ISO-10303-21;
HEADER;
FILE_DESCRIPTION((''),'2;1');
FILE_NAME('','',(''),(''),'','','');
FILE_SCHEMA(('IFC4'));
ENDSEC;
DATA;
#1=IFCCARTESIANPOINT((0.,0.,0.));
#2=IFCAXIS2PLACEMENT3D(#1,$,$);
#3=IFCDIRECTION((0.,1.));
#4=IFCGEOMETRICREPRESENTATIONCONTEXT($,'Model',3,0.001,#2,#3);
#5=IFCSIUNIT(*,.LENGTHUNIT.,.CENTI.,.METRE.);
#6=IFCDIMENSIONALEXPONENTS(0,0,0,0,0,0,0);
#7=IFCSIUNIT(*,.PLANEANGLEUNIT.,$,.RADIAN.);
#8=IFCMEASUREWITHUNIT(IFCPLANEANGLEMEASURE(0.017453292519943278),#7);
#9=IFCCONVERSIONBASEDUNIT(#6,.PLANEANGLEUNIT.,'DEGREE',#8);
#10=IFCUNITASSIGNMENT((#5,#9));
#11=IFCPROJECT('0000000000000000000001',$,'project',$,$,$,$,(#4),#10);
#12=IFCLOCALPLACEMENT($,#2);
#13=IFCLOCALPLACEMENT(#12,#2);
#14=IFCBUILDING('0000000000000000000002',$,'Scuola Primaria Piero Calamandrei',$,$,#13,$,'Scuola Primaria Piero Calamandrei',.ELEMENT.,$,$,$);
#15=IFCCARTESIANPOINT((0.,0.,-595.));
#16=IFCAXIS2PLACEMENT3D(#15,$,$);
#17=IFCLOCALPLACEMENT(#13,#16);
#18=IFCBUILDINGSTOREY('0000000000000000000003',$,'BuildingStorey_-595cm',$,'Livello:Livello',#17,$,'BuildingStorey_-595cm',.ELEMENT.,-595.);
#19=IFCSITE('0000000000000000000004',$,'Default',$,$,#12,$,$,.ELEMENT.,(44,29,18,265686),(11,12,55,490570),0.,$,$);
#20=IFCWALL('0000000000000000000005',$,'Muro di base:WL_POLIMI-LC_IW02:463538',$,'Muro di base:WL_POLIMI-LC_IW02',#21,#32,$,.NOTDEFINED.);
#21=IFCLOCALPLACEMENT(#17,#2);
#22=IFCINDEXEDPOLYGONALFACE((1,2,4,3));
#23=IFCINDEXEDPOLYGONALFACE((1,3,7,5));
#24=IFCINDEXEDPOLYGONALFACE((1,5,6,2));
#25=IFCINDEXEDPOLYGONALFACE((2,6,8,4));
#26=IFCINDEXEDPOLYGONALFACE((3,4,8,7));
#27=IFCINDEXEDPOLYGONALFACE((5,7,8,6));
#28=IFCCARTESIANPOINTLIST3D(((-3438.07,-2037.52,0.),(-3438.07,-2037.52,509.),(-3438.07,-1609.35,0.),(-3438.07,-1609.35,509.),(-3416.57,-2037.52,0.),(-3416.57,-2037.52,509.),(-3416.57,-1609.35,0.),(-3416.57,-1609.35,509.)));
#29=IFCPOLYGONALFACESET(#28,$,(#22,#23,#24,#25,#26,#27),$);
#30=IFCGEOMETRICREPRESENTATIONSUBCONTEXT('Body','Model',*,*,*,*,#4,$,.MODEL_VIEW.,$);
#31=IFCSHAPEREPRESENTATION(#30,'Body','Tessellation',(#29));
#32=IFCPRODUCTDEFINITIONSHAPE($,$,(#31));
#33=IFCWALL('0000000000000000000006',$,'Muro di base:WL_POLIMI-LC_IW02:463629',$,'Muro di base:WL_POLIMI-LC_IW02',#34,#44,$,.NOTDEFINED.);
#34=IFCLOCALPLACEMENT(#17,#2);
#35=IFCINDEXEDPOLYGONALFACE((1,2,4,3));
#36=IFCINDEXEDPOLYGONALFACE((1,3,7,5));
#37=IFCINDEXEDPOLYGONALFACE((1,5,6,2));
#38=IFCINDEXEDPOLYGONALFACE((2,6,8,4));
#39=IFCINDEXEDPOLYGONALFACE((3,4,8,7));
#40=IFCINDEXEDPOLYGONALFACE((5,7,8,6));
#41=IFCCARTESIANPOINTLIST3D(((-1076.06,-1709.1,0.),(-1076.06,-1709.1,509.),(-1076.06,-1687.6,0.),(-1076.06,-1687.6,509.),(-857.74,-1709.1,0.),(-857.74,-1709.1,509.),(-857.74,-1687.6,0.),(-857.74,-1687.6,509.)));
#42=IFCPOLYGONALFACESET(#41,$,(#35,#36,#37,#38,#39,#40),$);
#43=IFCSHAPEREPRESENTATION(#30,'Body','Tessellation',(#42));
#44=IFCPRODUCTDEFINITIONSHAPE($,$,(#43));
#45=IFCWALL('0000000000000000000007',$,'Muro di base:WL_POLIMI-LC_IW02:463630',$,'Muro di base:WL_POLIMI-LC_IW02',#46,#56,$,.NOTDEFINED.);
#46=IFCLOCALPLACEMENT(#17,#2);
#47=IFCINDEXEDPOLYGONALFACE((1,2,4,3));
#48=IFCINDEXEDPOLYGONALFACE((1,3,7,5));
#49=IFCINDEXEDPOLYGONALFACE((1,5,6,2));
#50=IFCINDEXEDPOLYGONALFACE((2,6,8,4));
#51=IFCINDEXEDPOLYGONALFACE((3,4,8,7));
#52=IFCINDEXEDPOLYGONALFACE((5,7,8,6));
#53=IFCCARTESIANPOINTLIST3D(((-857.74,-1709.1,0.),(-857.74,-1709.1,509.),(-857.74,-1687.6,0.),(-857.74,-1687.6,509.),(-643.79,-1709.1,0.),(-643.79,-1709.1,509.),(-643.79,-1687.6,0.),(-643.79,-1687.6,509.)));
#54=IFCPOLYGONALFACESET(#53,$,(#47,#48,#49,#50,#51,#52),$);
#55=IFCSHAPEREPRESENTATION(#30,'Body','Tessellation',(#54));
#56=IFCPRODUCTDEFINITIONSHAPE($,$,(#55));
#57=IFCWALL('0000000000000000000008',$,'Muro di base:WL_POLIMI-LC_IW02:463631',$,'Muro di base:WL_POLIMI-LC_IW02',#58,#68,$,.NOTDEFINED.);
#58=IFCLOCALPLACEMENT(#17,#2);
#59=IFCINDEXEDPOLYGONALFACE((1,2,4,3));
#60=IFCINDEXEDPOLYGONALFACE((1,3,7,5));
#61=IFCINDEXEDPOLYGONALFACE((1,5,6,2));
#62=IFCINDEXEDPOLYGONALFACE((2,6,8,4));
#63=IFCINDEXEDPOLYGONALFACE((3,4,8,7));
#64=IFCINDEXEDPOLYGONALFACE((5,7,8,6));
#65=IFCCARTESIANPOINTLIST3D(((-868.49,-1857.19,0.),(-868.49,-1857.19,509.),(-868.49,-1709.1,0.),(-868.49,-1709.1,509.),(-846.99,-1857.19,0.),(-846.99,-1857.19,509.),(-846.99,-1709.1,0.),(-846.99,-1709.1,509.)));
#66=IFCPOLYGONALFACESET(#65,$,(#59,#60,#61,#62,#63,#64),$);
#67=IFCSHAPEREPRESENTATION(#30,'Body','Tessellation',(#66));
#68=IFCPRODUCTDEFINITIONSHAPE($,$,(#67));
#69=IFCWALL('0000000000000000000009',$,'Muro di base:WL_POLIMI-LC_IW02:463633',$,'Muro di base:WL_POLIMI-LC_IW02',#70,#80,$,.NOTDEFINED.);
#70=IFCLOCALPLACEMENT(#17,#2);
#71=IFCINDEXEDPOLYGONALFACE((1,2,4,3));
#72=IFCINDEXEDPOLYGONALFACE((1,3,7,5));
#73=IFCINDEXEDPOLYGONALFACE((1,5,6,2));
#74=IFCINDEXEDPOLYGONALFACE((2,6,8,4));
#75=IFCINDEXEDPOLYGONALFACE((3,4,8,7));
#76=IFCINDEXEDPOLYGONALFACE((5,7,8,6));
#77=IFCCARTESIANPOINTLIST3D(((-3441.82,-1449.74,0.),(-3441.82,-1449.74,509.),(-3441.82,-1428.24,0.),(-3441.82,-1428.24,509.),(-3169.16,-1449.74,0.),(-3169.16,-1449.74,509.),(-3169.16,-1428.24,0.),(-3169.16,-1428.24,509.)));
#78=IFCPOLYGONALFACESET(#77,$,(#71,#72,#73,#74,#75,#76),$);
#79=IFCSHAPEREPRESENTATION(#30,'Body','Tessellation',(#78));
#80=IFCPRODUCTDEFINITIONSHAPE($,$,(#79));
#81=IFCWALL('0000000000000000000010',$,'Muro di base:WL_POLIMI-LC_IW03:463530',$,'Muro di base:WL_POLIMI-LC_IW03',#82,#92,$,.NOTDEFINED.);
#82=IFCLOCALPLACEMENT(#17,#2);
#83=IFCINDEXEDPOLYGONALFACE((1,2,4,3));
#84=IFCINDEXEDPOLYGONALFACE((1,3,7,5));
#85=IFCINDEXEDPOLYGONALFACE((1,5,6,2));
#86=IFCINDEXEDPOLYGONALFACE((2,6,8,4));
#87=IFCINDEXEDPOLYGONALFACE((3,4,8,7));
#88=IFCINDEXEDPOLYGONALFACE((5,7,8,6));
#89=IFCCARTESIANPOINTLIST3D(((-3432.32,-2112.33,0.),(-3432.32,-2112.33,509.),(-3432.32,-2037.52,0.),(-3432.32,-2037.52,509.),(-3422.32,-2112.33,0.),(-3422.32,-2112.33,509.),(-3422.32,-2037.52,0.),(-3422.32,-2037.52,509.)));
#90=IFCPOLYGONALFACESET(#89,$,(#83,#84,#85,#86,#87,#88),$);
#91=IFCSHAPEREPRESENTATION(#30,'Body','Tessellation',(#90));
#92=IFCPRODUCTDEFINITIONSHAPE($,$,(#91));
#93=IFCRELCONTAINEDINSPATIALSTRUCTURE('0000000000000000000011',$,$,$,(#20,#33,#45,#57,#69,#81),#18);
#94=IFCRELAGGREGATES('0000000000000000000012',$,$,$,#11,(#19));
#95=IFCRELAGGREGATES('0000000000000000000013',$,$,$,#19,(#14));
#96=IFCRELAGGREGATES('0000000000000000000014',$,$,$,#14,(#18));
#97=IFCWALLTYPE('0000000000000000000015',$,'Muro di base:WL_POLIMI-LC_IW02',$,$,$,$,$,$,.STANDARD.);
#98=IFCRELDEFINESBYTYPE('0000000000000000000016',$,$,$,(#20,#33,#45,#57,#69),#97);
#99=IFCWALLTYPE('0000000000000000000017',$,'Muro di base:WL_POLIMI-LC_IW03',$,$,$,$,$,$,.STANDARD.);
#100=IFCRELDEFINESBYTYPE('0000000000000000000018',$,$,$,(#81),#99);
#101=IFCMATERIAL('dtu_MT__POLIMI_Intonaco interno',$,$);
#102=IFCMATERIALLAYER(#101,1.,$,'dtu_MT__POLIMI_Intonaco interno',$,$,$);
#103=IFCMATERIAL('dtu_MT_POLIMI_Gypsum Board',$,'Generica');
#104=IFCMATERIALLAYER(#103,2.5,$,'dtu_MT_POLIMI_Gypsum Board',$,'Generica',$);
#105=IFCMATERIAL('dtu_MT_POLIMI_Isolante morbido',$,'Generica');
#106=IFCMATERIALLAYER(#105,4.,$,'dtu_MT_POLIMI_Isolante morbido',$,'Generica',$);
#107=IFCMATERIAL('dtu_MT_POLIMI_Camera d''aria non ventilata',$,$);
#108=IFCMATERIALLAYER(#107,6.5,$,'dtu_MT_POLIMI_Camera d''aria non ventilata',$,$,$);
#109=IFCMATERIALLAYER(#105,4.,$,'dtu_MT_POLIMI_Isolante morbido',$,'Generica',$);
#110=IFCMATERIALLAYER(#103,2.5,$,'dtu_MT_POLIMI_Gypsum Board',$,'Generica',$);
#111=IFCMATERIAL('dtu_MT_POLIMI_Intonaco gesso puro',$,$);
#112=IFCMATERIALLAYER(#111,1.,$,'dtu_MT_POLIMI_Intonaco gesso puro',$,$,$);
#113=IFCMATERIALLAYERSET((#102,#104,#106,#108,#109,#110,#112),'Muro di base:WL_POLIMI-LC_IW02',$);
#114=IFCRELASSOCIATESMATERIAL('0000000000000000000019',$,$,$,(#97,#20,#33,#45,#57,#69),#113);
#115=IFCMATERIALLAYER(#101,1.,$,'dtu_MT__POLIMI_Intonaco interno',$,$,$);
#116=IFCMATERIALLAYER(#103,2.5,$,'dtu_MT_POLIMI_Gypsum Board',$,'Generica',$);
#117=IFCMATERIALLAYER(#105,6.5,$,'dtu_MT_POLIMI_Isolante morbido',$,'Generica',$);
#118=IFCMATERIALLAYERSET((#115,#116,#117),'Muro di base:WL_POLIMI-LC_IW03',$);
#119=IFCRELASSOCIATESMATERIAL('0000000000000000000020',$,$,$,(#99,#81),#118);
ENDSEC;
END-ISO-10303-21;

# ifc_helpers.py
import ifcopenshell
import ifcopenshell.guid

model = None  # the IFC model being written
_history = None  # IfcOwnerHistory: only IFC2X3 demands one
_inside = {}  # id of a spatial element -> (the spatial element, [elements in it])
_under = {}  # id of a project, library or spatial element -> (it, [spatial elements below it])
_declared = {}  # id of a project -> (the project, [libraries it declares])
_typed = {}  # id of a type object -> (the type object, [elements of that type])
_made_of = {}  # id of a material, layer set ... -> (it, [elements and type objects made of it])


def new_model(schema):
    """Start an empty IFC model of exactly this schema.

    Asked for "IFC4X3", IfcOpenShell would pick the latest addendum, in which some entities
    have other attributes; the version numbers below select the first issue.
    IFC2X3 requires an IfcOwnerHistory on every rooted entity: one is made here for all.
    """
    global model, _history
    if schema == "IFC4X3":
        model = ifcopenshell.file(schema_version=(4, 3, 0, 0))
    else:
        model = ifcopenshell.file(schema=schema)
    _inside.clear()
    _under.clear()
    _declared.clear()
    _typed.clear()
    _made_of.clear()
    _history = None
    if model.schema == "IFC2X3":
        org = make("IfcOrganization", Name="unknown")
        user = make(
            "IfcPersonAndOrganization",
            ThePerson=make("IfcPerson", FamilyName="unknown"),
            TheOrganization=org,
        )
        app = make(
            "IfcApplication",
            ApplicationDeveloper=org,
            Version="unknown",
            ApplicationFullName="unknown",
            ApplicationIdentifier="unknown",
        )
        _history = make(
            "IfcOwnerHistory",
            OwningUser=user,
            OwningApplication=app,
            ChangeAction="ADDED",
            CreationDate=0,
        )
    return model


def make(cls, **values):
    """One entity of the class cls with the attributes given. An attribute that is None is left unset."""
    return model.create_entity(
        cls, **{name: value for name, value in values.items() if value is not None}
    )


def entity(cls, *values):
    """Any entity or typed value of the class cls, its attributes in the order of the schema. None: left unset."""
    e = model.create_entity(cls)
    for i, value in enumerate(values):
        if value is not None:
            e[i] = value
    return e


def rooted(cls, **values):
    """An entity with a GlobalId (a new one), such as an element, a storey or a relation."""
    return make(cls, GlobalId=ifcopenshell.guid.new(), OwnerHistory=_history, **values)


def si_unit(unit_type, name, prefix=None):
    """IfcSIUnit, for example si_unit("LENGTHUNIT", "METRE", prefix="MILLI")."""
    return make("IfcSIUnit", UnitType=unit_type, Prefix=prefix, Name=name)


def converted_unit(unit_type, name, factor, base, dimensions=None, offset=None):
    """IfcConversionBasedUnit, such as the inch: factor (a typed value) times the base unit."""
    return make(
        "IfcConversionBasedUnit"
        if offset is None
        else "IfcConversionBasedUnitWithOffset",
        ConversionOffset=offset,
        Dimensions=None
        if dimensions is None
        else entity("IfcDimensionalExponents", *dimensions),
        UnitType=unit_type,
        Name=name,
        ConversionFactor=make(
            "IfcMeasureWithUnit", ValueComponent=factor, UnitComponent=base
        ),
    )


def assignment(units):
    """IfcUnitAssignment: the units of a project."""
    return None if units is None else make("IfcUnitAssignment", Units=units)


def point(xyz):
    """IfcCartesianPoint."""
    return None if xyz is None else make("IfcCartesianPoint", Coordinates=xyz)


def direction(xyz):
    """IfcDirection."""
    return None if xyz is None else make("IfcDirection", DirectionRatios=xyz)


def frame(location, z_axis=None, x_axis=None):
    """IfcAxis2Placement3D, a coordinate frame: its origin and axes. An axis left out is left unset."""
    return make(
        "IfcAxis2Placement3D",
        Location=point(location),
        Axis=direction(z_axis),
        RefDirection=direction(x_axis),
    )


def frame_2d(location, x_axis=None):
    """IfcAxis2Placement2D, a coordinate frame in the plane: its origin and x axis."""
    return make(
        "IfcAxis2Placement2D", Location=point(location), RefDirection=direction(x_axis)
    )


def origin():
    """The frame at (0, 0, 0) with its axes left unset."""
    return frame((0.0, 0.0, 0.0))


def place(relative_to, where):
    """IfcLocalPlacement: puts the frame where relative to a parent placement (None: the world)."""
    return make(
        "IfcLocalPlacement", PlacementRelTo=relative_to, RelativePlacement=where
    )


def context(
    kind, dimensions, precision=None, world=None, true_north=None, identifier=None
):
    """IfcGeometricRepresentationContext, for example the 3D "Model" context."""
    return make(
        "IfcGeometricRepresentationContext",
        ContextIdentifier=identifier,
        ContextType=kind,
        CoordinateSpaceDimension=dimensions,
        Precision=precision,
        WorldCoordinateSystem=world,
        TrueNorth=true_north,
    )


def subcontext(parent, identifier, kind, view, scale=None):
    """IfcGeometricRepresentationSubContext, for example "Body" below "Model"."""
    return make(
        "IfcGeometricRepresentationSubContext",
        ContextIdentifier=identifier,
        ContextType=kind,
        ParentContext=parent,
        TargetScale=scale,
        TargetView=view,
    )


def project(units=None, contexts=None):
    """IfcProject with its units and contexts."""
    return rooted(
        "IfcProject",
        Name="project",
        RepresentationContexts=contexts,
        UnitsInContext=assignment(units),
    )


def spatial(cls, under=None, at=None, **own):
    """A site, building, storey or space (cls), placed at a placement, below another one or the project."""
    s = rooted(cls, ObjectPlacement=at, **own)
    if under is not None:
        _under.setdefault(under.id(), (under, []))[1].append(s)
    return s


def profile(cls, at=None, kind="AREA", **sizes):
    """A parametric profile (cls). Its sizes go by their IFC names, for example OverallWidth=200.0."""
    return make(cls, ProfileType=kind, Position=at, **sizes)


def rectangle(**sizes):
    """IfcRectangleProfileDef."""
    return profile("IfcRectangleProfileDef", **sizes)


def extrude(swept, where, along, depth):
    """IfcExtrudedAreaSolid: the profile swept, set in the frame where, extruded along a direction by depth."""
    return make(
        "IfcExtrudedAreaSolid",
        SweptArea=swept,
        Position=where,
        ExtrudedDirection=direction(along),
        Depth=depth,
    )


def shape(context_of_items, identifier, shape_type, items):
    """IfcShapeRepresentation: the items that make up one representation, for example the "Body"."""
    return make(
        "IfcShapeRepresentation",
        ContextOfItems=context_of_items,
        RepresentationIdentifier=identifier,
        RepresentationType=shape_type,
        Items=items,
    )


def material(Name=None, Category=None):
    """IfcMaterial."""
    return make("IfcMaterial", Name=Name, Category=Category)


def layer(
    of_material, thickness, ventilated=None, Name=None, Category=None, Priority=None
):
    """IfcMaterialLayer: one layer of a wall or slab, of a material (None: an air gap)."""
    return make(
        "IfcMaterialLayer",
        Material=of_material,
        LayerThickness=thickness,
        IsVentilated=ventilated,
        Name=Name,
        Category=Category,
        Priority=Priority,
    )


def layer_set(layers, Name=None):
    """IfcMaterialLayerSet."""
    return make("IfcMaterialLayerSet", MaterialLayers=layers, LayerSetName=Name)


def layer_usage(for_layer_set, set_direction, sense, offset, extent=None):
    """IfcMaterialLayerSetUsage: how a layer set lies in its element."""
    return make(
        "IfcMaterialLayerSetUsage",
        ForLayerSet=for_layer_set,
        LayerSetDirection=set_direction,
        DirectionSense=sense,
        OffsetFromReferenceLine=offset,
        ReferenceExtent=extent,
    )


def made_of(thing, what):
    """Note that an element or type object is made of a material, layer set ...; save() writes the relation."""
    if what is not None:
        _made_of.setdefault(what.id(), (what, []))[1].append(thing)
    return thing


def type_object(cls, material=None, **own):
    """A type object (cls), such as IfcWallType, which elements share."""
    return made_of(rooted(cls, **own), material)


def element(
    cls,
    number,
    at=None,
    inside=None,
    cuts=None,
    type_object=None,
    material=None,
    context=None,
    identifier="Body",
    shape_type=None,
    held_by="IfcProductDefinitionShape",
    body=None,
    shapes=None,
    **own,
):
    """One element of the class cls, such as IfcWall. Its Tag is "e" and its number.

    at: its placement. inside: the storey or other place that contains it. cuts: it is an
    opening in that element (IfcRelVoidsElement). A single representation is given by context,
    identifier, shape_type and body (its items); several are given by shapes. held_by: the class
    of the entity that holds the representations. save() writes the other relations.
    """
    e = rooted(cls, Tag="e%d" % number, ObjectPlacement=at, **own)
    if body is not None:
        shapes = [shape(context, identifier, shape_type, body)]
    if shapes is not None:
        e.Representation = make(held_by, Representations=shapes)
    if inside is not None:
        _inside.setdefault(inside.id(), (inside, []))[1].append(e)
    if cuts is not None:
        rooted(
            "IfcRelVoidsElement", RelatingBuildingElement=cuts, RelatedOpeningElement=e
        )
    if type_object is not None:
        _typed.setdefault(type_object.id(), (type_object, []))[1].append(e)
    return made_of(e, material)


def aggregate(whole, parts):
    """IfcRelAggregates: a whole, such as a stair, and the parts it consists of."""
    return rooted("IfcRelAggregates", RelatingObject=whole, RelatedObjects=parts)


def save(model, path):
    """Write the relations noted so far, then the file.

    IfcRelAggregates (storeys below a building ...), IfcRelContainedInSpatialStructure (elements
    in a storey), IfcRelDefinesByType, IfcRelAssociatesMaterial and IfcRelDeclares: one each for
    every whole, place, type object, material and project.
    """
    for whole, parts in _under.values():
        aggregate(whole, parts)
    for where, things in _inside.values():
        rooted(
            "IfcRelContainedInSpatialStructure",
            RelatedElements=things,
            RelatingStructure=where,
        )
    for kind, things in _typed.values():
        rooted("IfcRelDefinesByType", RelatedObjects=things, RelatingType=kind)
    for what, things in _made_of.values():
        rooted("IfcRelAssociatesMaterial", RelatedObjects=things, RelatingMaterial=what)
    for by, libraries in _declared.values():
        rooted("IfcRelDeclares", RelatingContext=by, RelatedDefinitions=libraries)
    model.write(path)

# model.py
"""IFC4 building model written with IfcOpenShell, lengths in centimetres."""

from ifc_helpers import new_model, entity, si_unit, converted_unit, direction, frame, frame_2d, origin, place, context, subcontext, project, spatial, rectangle, extrude, material, layer, layer_set, layer_usage, type_object, element, save


model = new_model("IFC4")

# Units and contexts
model_context = context("Model", 3, precision=0.001, world=origin(), true_north=direction((0.0, 1.0)))
body_context = subcontext(model_context, "Body", "Model", "MODEL_VIEW")
ifc_project = project(units=[si_unit("LENGTHUNIT", "METRE", prefix="CENTI"), converted_unit("PLANEANGLEUNIT", "DEGREE", entity("IfcPlaneAngleMeasure", 0.017453292519943278), si_unit("PLANEANGLEUNIT", "RADIAN"), dimensions=[0, 0, 0, 0, 0, 0, 0])], contexts=[model_context])

# Site, building, storey
site_placement = place(None, origin())
site = spatial("IfcSite", under=ifc_project, at=site_placement, Name="Default", CompositionType="ELEMENT", RefLatitude=(44, 29, 18, 265686), RefLongitude=(11, 12, 55, 490570), RefElevation=0.0)
building_placement = place(site_placement, origin())
building = spatial("IfcBuilding", under=site, at=building_placement, Name="Scuola Primaria Piero Calamandrei", LongName="Scuola Primaria Piero Calamandrei", CompositionType="ELEMENT")
storey_placement = place(building_placement, frame((0.0, 0.0, -595.0)))
storey = spatial("IfcBuildingStorey", under=building, at=storey_placement, Name="BuildingStorey_-595cm", ObjectType="Livello:Livello", LongName="BuildingStorey_-595cm", CompositionType="ELEMENT", Elevation=-595.0)

# Shared definitions
ifc_material_1 = material(Name="dtu_MT__POLIMI_Intonaco interno")

# Shared definitions
ifc_layer_1 = layer(ifc_material_1, 1.0, Name="dtu_MT__POLIMI_Intonaco interno")
ifc_material_2 = material(Name="dtu_MT_POLIMI_Gypsum Board", Category="Generica")
ifc_layer_2 = layer(ifc_material_2, 2.5, Name="dtu_MT_POLIMI_Gypsum Board", Category="Generica")
ifc_material_3 = material(Name="dtu_MT_POLIMI_Isolante morbido", Category="Generica")
ifc_layer_3 = layer(ifc_material_3, 4.0, Name="dtu_MT_POLIMI_Isolante morbido", Category="Generica")
ifc_material_4 = material(Name="dtu_MT_POLIMI_Camera d'aria non ventilata")
ifc_layer_4 = layer(ifc_material_4, 6.5, Name="dtu_MT_POLIMI_Camera d'aria non ventilata")
ifc_layer_5 = layer(ifc_material_3, 4.0, Name="dtu_MT_POLIMI_Isolante morbido", Category="Generica")
ifc_layer_6 = layer(ifc_material_2, 2.5, Name="dtu_MT_POLIMI_Gypsum Board", Category="Generica")
ifc_material_5 = material(Name="dtu_MT_POLIMI_Intonaco gesso puro")
ifc_layer_7 = layer(ifc_material_5, 1.0, Name="dtu_MT_POLIMI_Intonaco gesso puro")
ifc_layer_set_1 = layer_set([ifc_layer_1, ifc_layer_2, ifc_layer_3, ifc_layer_4, ifc_layer_5, ifc_layer_6, ifc_layer_7], Name="Muro di base:WL_POLIMI-LC_IW02")
wall_type_1 = type_object("IfcWallType", Name="Muro di base:WL_POLIMI-LC_IW02", PredefinedType="STANDARD", material=ifc_layer_set_1)

# Walls
ifc_layer_usage_1 = layer_usage(ifc_layer_set_1, "AXIS2", "NEGATIVE", 10.75)
wall_1_placement = place(storey_placement, frame((-3427.32, -2037.52, 0.0), z_axis=(0.0, 0.0, 1.0), x_axis=(0.0, 1.0, 0.0)))
element("IfcWall", 1, at=wall_1_placement, inside=storey, type_object=wall_type_1, material=ifc_layer_usage_1, Name="Muro di base:WL_POLIMI-LC_IW02:463538", ObjectType="Muro di base:WL_POLIMI-LC_IW02", PredefinedType="NOTDEFINED", context=body_context, shape_type="SweptSolid", body=[
    extrude(rectangle(XDim=428.17, YDim=21.5, at=frame_2d((214.09, 0.0), x_axis=(-1.0, 0.0))), origin(), (0.0, 0.0, 1.0), 509.0),
])
ifc_layer_usage_2 = layer_usage(ifc_layer_set_1, "AXIS2", "NEGATIVE", 10.75)
wall_2_placement = place(storey_placement, frame((-857.74, -1698.35, 0.0), z_axis=(0.0, 0.0, 1.0), x_axis=(-1.0, 0.0, 0.0)))
element("IfcWall", 2, at=wall_2_placement, inside=storey, type_object=wall_type_1, material=ifc_layer_usage_2, Name="Muro di base:WL_POLIMI-LC_IW02:463629", ObjectType="Muro di base:WL_POLIMI-LC_IW02", PredefinedType="NOTDEFINED", context=body_context, shape_type="SweptSolid", body=[
    extrude(rectangle(XDim=218.32, YDim=21.5, at=frame_2d((109.16, 0.0), x_axis=(-1.0, 0.0))), origin(), (0.0, 0.0, 1.0), 509.0),
])
ifc_layer_usage_3 = layer_usage(ifc_layer_set_1, "AXIS2", "NEGATIVE", 10.75)
wall_3_placement = place(storey_placement, frame((-643.79, -1698.35, 0.0), z_axis=(0.0, 0.0, 1.0), x_axis=(-1.0, 0.0, 0.0)))
element("IfcWall", 3, at=wall_3_placement, inside=storey, type_object=wall_type_1, material=ifc_layer_usage_3, Name="Muro di base:WL_POLIMI-LC_IW02:463630", ObjectType="Muro di base:WL_POLIMI-LC_IW02", PredefinedType="NOTDEFINED", context=body_context, shape_type="SweptSolid", body=[
    extrude(rectangle(XDim=213.95, YDim=21.5, at=frame_2d((106.98, 0.0), x_axis=(-1.0, 0.0))), origin(), (0.0, 0.0, 1.0), 509.0),
])
ifc_layer_usage_4 = layer_usage(ifc_layer_set_1, "AXIS2", "NEGATIVE", 10.75)
wall_4_placement = place(storey_placement, frame((-857.74, -1709.1, 0.0), z_axis=(0.0, 0.0, 1.0), x_axis=(0.0, -1.0, 0.0)))
element("IfcWall", 4, at=wall_4_placement, inside=storey, type_object=wall_type_1, material=ifc_layer_usage_4, Name="Muro di base:WL_POLIMI-LC_IW02:463631", ObjectType="Muro di base:WL_POLIMI-LC_IW02", PredefinedType="NOTDEFINED", context=body_context, shape_type="SweptSolid", body=[
    extrude(rectangle(XDim=148.08, YDim=21.5, at=frame_2d((74.04, 0.0), x_axis=(-1.0, 0.0))), origin(), (0.0, 0.0, 1.0), 509.0),
])
ifc_layer_usage_5 = layer_usage(ifc_layer_set_1, "AXIS2", "NEGATIVE", 10.75)
wall_5_placement = place(storey_placement, frame((-3169.16, -1438.99, 0.0), z_axis=(0.0, 0.0, 1.0), x_axis=(-1.0, 0.0, 0.0)))
element("IfcWall", 5, at=wall_5_placement, inside=storey, type_object=wall_type_1, material=ifc_layer_usage_5, Name="Muro di base:WL_POLIMI-LC_IW02:463633", ObjectType="Muro di base:WL_POLIMI-LC_IW02", PredefinedType="NOTDEFINED", context=body_context, shape_type="SweptSolid", body=[
    extrude(rectangle(XDim=272.66, YDim=21.5, at=frame_2d((136.33, 0.0), x_axis=(-1.0, 0.0))), origin(), (0.0, 0.0, 1.0), 509.0),
])
ifc_layer_8 = layer(ifc_material_1, 1.0, Name="dtu_MT__POLIMI_Intonaco interno")
ifc_layer_9 = layer(ifc_material_2, 2.5, Name="dtu_MT_POLIMI_Gypsum Board", Category="Generica")
ifc_layer_10 = layer(ifc_material_3, 6.5, Name="dtu_MT_POLIMI_Isolante morbido", Category="Generica")
ifc_layer_set_2 = layer_set([ifc_layer_8, ifc_layer_9, ifc_layer_10], Name="Muro di base:WL_POLIMI-LC_IW03")
ifc_layer_usage_6 = layer_usage(ifc_layer_set_2, "AXIS2", "NEGATIVE", 5.0)
wall_type_2 = type_object("IfcWallType", Name="Muro di base:WL_POLIMI-LC_IW03", PredefinedType="STANDARD", material=ifc_layer_set_2)
wall_6_placement = place(storey_placement, frame((-3427.32, -2112.33, 0.0), z_axis=(0.0, 0.0, 1.0), x_axis=(0.0, 1.0, 0.0)))
element("IfcWall", 6, at=wall_6_placement, inside=storey, type_object=wall_type_2, material=ifc_layer_usage_6, Name="Muro di base:WL_POLIMI-LC_IW03:463530", ObjectType="Muro di base:WL_POLIMI-LC_IW03", PredefinedType="NOTDEFINED", context=body_context, shape_type="SweptSolid", body=[
    extrude(rectangle(XDim=74.8, YDim=10.0, at=frame_2d((37.4, 0.0), x_axis=(-1.0, 0.0))), origin(), (0.0, 0.0, 1.0), 509.0),
])

save(model, "model.ifc")
